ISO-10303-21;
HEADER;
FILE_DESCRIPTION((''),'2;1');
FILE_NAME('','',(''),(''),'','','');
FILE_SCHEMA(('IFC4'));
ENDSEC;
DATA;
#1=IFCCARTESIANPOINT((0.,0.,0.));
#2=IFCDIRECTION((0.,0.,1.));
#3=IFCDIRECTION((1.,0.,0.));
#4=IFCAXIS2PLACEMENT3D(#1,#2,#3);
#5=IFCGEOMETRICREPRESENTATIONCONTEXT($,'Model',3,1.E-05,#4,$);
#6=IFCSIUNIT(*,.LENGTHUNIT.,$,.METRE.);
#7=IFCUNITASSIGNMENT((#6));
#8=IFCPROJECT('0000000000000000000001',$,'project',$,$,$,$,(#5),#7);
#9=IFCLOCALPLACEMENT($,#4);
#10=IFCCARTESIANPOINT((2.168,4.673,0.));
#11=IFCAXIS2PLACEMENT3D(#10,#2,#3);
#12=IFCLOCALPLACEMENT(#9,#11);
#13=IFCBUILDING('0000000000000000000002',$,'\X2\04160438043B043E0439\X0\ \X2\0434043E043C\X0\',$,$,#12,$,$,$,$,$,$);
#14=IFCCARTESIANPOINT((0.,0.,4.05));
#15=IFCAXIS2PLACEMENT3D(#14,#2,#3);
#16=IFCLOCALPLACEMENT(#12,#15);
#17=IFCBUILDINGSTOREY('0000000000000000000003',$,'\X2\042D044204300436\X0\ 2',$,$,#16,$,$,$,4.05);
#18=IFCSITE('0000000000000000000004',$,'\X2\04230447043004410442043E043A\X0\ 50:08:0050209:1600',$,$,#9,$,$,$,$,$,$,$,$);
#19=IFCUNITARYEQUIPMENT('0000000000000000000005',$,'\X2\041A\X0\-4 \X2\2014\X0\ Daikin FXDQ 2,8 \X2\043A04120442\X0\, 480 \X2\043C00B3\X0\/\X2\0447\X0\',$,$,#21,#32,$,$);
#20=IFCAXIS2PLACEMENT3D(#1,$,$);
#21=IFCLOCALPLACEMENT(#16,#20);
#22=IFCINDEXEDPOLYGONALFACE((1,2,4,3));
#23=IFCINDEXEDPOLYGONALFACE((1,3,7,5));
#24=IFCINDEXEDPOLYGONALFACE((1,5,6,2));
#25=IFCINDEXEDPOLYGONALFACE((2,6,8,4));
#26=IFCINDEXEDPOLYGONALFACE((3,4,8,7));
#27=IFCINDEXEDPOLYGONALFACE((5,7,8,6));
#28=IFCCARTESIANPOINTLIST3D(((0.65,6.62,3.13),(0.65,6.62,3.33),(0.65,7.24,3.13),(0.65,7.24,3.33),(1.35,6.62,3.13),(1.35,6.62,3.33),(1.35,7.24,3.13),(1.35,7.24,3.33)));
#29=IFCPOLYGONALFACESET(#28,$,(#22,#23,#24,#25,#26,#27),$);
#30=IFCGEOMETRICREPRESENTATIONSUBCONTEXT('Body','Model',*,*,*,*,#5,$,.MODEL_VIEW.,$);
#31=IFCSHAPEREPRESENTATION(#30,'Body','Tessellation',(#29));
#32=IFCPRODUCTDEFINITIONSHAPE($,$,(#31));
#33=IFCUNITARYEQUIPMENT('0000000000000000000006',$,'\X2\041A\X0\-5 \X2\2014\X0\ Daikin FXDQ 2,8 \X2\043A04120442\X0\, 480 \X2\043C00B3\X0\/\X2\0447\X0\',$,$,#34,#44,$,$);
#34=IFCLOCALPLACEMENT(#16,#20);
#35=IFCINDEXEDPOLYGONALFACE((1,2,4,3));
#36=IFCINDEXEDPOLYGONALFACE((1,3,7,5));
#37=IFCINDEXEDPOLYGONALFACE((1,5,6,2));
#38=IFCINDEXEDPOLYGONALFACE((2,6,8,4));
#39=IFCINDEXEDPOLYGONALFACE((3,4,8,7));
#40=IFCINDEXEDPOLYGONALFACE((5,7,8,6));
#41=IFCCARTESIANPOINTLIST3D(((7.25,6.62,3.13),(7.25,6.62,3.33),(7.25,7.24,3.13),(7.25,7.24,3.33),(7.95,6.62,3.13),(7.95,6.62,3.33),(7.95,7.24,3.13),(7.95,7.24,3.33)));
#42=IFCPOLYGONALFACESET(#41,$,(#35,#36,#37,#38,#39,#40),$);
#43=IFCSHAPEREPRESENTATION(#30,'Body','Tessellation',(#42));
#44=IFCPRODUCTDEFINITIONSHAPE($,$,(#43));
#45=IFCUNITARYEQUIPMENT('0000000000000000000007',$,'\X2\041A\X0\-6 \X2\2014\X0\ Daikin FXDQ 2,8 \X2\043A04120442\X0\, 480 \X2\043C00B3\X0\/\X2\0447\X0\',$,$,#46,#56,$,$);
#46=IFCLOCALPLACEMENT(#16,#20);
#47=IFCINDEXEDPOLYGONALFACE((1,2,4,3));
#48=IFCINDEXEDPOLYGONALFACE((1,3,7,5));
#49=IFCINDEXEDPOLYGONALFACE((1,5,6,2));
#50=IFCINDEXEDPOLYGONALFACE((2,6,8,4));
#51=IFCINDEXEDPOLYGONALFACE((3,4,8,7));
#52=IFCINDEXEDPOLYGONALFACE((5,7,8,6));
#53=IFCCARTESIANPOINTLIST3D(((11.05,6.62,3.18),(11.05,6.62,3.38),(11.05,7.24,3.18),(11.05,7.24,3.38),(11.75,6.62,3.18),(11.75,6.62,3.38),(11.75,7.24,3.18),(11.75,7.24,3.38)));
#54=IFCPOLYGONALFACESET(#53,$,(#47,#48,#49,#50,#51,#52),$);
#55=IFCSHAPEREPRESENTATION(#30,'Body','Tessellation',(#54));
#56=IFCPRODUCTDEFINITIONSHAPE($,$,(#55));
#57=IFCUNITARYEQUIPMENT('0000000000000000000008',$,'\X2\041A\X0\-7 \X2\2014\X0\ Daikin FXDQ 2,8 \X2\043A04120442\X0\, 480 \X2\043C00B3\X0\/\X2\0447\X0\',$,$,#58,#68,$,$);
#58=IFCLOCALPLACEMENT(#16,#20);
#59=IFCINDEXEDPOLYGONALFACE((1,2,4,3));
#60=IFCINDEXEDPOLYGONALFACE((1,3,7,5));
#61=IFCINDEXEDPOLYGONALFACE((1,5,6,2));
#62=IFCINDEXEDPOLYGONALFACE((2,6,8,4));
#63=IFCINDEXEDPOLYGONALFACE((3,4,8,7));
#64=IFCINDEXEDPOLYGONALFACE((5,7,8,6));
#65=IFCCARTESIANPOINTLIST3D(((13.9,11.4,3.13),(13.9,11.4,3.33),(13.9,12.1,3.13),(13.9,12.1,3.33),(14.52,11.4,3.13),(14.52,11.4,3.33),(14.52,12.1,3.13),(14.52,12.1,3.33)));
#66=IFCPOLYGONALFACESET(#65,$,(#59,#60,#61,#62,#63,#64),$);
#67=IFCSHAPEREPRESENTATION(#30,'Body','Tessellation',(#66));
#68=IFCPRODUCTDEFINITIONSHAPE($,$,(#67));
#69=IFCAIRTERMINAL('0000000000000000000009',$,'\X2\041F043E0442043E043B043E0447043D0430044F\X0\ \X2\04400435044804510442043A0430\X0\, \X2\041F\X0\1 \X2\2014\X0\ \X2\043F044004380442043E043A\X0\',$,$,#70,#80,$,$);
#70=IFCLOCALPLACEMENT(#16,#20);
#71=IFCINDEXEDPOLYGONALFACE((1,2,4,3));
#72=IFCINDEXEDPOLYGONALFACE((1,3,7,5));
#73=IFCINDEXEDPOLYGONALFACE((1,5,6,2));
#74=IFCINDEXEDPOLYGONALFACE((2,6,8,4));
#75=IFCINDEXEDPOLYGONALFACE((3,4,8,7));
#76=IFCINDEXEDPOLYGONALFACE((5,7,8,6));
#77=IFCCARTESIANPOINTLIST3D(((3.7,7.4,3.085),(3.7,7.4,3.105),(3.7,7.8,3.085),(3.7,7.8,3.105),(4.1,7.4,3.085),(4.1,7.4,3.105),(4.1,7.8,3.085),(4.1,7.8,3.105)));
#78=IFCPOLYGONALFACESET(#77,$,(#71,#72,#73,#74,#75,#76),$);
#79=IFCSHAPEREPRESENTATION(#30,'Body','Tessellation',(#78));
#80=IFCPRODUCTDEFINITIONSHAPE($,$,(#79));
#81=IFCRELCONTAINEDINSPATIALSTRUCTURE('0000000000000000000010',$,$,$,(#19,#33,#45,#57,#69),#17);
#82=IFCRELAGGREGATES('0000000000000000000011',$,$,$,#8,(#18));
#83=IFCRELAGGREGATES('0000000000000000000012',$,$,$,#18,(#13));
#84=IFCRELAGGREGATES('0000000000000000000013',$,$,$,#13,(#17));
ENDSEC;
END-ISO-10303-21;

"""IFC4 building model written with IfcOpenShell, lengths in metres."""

from ifc_helpers import new_model, si_unit, frame, frame_2d, origin_with_axes, place, context, subcontext, project, spatial, rectangle, extrude, element, save


model = new_model("IFC4")

# Units and contexts
model_context = context("Model", 3, precision=1e-05, world=origin_with_axes())
body_context = subcontext(model_context, "Body", "Model", "MODEL_VIEW")
ifc_project = project(units=[si_unit("LENGTHUNIT", "METRE")], contexts=[model_context])

# Site, building, storey
site_placement = place(None, origin_with_axes())
site = spatial("IfcSite", under=ifc_project, at=site_placement, Name="Участок 50:08:0050209:1600")
building_placement = place(site_placement, frame((2.168, 4.673, 0.0), z_axis=(0.0, 0.0, 1.0), x_axis=(1.0, 0.0, 0.0)))
building = spatial("IfcBuilding", under=site, at=building_placement, Name="Жилой дом")
storey_placement = place(building_placement, frame((0.0, 0.0, 4.05), z_axis=(0.0, 0.0, 1.0), x_axis=(1.0, 0.0, 0.0)))
storey = spatial("IfcBuildingStorey", under=building, at=storey_placement, Name="Этаж 2", Elevation=4.05)

# Unitary equipment
unitary_equipment_1_placement = place(storey_placement, frame((0.0, 0.0, -4.05), z_axis=(0.0, 0.0, 1.0), x_axis=(1.0, 0.0, 0.0)))
element("IfcUnitaryEquipment", 1, at=unitary_equipment_1_placement, inside=storey, Name="К-4 — Daikin FXDQ 2,8 кВт, 480 м³/ч", context=body_context, shape_type="SweptSolid", body=[
    extrude(rectangle(XDim=0.7, YDim=0.62, at=frame_2d((0.35, 0.31))), frame((0.65, 6.62, 7.18), z_axis=(0.0, 0.0, 1.0), x_axis=(1.0, 0.0, 0.0)), (0.0, 0.0, 1.0), 0.2),
])
unitary_equipment_2_placement = place(storey_placement, frame((0.0, 0.0, -4.05), z_axis=(0.0, 0.0, 1.0), x_axis=(1.0, 0.0, 0.0)))
element("IfcUnitaryEquipment", 2, at=unitary_equipment_2_placement, inside=storey, Name="К-5 — Daikin FXDQ 2,8 кВт, 480 м³/ч", context=body_context, shape_type="SweptSolid", body=[
    extrude(rectangle(XDim=0.7, YDim=0.62, at=frame_2d((0.35, 0.31))), frame((7.25, 6.62, 7.18), z_axis=(0.0, 0.0, 1.0), x_axis=(1.0, 0.0, 0.0)), (0.0, 0.0, 1.0), 0.2),
])
unitary_equipment_3_placement = place(storey_placement, frame((0.0, 0.0, -4.05), z_axis=(0.0, 0.0, 1.0), x_axis=(1.0, 0.0, 0.0)))
element("IfcUnitaryEquipment", 3, at=unitary_equipment_3_placement, inside=storey, Name="К-6 — Daikin FXDQ 2,8 кВт, 480 м³/ч", context=body_context, shape_type="SweptSolid", body=[
    extrude(rectangle(XDim=0.7, YDim=0.62, at=frame_2d((0.35, 0.31))), frame((11.05, 6.62, 7.23), z_axis=(0.0, 0.0, 1.0), x_axis=(1.0, 0.0, 0.0)), (0.0, 0.0, 1.0), 0.2),
])
unitary_equipment_4_placement = place(storey_placement, frame((0.0, 0.0, -4.05), z_axis=(0.0, 0.0, 1.0), x_axis=(1.0, 0.0, 0.0)))
element("IfcUnitaryEquipment", 4, at=unitary_equipment_4_placement, inside=storey, Name="К-7 — Daikin FXDQ 2,8 кВт, 480 м³/ч", context=body_context, shape_type="SweptSolid", body=[
    extrude(rectangle(XDim=0.62, YDim=0.7, at=frame_2d((0.31, 0.35))), frame((13.9, 11.4, 7.18), z_axis=(0.0, 0.0, 1.0), x_axis=(1.0, 0.0, 0.0)), (0.0, 0.0, 1.0), 0.2),
])

# Air terminal
air_terminal_placement = place(storey_placement, frame((0.0, 0.0, -4.05), z_axis=(0.0, 0.0, 1.0), x_axis=(1.0, 0.0, 0.0)))
element("IfcAirTerminal", 5, at=air_terminal_placement, inside=storey, Name="Потолочная решётка, П1 — приток", context=body_context, shape_type="SweptSolid", body=[
    extrude(rectangle(XDim=0.4, YDim=0.4, at=frame_2d((0.2, 0.2))), frame((3.7, 7.4, 7.135), z_axis=(0.0, 0.0, 1.0), x_axis=(1.0, 0.0, 0.0)), (0.0, 0.0, 1.0), 0.02),
])

save(model, "model.ifc")
